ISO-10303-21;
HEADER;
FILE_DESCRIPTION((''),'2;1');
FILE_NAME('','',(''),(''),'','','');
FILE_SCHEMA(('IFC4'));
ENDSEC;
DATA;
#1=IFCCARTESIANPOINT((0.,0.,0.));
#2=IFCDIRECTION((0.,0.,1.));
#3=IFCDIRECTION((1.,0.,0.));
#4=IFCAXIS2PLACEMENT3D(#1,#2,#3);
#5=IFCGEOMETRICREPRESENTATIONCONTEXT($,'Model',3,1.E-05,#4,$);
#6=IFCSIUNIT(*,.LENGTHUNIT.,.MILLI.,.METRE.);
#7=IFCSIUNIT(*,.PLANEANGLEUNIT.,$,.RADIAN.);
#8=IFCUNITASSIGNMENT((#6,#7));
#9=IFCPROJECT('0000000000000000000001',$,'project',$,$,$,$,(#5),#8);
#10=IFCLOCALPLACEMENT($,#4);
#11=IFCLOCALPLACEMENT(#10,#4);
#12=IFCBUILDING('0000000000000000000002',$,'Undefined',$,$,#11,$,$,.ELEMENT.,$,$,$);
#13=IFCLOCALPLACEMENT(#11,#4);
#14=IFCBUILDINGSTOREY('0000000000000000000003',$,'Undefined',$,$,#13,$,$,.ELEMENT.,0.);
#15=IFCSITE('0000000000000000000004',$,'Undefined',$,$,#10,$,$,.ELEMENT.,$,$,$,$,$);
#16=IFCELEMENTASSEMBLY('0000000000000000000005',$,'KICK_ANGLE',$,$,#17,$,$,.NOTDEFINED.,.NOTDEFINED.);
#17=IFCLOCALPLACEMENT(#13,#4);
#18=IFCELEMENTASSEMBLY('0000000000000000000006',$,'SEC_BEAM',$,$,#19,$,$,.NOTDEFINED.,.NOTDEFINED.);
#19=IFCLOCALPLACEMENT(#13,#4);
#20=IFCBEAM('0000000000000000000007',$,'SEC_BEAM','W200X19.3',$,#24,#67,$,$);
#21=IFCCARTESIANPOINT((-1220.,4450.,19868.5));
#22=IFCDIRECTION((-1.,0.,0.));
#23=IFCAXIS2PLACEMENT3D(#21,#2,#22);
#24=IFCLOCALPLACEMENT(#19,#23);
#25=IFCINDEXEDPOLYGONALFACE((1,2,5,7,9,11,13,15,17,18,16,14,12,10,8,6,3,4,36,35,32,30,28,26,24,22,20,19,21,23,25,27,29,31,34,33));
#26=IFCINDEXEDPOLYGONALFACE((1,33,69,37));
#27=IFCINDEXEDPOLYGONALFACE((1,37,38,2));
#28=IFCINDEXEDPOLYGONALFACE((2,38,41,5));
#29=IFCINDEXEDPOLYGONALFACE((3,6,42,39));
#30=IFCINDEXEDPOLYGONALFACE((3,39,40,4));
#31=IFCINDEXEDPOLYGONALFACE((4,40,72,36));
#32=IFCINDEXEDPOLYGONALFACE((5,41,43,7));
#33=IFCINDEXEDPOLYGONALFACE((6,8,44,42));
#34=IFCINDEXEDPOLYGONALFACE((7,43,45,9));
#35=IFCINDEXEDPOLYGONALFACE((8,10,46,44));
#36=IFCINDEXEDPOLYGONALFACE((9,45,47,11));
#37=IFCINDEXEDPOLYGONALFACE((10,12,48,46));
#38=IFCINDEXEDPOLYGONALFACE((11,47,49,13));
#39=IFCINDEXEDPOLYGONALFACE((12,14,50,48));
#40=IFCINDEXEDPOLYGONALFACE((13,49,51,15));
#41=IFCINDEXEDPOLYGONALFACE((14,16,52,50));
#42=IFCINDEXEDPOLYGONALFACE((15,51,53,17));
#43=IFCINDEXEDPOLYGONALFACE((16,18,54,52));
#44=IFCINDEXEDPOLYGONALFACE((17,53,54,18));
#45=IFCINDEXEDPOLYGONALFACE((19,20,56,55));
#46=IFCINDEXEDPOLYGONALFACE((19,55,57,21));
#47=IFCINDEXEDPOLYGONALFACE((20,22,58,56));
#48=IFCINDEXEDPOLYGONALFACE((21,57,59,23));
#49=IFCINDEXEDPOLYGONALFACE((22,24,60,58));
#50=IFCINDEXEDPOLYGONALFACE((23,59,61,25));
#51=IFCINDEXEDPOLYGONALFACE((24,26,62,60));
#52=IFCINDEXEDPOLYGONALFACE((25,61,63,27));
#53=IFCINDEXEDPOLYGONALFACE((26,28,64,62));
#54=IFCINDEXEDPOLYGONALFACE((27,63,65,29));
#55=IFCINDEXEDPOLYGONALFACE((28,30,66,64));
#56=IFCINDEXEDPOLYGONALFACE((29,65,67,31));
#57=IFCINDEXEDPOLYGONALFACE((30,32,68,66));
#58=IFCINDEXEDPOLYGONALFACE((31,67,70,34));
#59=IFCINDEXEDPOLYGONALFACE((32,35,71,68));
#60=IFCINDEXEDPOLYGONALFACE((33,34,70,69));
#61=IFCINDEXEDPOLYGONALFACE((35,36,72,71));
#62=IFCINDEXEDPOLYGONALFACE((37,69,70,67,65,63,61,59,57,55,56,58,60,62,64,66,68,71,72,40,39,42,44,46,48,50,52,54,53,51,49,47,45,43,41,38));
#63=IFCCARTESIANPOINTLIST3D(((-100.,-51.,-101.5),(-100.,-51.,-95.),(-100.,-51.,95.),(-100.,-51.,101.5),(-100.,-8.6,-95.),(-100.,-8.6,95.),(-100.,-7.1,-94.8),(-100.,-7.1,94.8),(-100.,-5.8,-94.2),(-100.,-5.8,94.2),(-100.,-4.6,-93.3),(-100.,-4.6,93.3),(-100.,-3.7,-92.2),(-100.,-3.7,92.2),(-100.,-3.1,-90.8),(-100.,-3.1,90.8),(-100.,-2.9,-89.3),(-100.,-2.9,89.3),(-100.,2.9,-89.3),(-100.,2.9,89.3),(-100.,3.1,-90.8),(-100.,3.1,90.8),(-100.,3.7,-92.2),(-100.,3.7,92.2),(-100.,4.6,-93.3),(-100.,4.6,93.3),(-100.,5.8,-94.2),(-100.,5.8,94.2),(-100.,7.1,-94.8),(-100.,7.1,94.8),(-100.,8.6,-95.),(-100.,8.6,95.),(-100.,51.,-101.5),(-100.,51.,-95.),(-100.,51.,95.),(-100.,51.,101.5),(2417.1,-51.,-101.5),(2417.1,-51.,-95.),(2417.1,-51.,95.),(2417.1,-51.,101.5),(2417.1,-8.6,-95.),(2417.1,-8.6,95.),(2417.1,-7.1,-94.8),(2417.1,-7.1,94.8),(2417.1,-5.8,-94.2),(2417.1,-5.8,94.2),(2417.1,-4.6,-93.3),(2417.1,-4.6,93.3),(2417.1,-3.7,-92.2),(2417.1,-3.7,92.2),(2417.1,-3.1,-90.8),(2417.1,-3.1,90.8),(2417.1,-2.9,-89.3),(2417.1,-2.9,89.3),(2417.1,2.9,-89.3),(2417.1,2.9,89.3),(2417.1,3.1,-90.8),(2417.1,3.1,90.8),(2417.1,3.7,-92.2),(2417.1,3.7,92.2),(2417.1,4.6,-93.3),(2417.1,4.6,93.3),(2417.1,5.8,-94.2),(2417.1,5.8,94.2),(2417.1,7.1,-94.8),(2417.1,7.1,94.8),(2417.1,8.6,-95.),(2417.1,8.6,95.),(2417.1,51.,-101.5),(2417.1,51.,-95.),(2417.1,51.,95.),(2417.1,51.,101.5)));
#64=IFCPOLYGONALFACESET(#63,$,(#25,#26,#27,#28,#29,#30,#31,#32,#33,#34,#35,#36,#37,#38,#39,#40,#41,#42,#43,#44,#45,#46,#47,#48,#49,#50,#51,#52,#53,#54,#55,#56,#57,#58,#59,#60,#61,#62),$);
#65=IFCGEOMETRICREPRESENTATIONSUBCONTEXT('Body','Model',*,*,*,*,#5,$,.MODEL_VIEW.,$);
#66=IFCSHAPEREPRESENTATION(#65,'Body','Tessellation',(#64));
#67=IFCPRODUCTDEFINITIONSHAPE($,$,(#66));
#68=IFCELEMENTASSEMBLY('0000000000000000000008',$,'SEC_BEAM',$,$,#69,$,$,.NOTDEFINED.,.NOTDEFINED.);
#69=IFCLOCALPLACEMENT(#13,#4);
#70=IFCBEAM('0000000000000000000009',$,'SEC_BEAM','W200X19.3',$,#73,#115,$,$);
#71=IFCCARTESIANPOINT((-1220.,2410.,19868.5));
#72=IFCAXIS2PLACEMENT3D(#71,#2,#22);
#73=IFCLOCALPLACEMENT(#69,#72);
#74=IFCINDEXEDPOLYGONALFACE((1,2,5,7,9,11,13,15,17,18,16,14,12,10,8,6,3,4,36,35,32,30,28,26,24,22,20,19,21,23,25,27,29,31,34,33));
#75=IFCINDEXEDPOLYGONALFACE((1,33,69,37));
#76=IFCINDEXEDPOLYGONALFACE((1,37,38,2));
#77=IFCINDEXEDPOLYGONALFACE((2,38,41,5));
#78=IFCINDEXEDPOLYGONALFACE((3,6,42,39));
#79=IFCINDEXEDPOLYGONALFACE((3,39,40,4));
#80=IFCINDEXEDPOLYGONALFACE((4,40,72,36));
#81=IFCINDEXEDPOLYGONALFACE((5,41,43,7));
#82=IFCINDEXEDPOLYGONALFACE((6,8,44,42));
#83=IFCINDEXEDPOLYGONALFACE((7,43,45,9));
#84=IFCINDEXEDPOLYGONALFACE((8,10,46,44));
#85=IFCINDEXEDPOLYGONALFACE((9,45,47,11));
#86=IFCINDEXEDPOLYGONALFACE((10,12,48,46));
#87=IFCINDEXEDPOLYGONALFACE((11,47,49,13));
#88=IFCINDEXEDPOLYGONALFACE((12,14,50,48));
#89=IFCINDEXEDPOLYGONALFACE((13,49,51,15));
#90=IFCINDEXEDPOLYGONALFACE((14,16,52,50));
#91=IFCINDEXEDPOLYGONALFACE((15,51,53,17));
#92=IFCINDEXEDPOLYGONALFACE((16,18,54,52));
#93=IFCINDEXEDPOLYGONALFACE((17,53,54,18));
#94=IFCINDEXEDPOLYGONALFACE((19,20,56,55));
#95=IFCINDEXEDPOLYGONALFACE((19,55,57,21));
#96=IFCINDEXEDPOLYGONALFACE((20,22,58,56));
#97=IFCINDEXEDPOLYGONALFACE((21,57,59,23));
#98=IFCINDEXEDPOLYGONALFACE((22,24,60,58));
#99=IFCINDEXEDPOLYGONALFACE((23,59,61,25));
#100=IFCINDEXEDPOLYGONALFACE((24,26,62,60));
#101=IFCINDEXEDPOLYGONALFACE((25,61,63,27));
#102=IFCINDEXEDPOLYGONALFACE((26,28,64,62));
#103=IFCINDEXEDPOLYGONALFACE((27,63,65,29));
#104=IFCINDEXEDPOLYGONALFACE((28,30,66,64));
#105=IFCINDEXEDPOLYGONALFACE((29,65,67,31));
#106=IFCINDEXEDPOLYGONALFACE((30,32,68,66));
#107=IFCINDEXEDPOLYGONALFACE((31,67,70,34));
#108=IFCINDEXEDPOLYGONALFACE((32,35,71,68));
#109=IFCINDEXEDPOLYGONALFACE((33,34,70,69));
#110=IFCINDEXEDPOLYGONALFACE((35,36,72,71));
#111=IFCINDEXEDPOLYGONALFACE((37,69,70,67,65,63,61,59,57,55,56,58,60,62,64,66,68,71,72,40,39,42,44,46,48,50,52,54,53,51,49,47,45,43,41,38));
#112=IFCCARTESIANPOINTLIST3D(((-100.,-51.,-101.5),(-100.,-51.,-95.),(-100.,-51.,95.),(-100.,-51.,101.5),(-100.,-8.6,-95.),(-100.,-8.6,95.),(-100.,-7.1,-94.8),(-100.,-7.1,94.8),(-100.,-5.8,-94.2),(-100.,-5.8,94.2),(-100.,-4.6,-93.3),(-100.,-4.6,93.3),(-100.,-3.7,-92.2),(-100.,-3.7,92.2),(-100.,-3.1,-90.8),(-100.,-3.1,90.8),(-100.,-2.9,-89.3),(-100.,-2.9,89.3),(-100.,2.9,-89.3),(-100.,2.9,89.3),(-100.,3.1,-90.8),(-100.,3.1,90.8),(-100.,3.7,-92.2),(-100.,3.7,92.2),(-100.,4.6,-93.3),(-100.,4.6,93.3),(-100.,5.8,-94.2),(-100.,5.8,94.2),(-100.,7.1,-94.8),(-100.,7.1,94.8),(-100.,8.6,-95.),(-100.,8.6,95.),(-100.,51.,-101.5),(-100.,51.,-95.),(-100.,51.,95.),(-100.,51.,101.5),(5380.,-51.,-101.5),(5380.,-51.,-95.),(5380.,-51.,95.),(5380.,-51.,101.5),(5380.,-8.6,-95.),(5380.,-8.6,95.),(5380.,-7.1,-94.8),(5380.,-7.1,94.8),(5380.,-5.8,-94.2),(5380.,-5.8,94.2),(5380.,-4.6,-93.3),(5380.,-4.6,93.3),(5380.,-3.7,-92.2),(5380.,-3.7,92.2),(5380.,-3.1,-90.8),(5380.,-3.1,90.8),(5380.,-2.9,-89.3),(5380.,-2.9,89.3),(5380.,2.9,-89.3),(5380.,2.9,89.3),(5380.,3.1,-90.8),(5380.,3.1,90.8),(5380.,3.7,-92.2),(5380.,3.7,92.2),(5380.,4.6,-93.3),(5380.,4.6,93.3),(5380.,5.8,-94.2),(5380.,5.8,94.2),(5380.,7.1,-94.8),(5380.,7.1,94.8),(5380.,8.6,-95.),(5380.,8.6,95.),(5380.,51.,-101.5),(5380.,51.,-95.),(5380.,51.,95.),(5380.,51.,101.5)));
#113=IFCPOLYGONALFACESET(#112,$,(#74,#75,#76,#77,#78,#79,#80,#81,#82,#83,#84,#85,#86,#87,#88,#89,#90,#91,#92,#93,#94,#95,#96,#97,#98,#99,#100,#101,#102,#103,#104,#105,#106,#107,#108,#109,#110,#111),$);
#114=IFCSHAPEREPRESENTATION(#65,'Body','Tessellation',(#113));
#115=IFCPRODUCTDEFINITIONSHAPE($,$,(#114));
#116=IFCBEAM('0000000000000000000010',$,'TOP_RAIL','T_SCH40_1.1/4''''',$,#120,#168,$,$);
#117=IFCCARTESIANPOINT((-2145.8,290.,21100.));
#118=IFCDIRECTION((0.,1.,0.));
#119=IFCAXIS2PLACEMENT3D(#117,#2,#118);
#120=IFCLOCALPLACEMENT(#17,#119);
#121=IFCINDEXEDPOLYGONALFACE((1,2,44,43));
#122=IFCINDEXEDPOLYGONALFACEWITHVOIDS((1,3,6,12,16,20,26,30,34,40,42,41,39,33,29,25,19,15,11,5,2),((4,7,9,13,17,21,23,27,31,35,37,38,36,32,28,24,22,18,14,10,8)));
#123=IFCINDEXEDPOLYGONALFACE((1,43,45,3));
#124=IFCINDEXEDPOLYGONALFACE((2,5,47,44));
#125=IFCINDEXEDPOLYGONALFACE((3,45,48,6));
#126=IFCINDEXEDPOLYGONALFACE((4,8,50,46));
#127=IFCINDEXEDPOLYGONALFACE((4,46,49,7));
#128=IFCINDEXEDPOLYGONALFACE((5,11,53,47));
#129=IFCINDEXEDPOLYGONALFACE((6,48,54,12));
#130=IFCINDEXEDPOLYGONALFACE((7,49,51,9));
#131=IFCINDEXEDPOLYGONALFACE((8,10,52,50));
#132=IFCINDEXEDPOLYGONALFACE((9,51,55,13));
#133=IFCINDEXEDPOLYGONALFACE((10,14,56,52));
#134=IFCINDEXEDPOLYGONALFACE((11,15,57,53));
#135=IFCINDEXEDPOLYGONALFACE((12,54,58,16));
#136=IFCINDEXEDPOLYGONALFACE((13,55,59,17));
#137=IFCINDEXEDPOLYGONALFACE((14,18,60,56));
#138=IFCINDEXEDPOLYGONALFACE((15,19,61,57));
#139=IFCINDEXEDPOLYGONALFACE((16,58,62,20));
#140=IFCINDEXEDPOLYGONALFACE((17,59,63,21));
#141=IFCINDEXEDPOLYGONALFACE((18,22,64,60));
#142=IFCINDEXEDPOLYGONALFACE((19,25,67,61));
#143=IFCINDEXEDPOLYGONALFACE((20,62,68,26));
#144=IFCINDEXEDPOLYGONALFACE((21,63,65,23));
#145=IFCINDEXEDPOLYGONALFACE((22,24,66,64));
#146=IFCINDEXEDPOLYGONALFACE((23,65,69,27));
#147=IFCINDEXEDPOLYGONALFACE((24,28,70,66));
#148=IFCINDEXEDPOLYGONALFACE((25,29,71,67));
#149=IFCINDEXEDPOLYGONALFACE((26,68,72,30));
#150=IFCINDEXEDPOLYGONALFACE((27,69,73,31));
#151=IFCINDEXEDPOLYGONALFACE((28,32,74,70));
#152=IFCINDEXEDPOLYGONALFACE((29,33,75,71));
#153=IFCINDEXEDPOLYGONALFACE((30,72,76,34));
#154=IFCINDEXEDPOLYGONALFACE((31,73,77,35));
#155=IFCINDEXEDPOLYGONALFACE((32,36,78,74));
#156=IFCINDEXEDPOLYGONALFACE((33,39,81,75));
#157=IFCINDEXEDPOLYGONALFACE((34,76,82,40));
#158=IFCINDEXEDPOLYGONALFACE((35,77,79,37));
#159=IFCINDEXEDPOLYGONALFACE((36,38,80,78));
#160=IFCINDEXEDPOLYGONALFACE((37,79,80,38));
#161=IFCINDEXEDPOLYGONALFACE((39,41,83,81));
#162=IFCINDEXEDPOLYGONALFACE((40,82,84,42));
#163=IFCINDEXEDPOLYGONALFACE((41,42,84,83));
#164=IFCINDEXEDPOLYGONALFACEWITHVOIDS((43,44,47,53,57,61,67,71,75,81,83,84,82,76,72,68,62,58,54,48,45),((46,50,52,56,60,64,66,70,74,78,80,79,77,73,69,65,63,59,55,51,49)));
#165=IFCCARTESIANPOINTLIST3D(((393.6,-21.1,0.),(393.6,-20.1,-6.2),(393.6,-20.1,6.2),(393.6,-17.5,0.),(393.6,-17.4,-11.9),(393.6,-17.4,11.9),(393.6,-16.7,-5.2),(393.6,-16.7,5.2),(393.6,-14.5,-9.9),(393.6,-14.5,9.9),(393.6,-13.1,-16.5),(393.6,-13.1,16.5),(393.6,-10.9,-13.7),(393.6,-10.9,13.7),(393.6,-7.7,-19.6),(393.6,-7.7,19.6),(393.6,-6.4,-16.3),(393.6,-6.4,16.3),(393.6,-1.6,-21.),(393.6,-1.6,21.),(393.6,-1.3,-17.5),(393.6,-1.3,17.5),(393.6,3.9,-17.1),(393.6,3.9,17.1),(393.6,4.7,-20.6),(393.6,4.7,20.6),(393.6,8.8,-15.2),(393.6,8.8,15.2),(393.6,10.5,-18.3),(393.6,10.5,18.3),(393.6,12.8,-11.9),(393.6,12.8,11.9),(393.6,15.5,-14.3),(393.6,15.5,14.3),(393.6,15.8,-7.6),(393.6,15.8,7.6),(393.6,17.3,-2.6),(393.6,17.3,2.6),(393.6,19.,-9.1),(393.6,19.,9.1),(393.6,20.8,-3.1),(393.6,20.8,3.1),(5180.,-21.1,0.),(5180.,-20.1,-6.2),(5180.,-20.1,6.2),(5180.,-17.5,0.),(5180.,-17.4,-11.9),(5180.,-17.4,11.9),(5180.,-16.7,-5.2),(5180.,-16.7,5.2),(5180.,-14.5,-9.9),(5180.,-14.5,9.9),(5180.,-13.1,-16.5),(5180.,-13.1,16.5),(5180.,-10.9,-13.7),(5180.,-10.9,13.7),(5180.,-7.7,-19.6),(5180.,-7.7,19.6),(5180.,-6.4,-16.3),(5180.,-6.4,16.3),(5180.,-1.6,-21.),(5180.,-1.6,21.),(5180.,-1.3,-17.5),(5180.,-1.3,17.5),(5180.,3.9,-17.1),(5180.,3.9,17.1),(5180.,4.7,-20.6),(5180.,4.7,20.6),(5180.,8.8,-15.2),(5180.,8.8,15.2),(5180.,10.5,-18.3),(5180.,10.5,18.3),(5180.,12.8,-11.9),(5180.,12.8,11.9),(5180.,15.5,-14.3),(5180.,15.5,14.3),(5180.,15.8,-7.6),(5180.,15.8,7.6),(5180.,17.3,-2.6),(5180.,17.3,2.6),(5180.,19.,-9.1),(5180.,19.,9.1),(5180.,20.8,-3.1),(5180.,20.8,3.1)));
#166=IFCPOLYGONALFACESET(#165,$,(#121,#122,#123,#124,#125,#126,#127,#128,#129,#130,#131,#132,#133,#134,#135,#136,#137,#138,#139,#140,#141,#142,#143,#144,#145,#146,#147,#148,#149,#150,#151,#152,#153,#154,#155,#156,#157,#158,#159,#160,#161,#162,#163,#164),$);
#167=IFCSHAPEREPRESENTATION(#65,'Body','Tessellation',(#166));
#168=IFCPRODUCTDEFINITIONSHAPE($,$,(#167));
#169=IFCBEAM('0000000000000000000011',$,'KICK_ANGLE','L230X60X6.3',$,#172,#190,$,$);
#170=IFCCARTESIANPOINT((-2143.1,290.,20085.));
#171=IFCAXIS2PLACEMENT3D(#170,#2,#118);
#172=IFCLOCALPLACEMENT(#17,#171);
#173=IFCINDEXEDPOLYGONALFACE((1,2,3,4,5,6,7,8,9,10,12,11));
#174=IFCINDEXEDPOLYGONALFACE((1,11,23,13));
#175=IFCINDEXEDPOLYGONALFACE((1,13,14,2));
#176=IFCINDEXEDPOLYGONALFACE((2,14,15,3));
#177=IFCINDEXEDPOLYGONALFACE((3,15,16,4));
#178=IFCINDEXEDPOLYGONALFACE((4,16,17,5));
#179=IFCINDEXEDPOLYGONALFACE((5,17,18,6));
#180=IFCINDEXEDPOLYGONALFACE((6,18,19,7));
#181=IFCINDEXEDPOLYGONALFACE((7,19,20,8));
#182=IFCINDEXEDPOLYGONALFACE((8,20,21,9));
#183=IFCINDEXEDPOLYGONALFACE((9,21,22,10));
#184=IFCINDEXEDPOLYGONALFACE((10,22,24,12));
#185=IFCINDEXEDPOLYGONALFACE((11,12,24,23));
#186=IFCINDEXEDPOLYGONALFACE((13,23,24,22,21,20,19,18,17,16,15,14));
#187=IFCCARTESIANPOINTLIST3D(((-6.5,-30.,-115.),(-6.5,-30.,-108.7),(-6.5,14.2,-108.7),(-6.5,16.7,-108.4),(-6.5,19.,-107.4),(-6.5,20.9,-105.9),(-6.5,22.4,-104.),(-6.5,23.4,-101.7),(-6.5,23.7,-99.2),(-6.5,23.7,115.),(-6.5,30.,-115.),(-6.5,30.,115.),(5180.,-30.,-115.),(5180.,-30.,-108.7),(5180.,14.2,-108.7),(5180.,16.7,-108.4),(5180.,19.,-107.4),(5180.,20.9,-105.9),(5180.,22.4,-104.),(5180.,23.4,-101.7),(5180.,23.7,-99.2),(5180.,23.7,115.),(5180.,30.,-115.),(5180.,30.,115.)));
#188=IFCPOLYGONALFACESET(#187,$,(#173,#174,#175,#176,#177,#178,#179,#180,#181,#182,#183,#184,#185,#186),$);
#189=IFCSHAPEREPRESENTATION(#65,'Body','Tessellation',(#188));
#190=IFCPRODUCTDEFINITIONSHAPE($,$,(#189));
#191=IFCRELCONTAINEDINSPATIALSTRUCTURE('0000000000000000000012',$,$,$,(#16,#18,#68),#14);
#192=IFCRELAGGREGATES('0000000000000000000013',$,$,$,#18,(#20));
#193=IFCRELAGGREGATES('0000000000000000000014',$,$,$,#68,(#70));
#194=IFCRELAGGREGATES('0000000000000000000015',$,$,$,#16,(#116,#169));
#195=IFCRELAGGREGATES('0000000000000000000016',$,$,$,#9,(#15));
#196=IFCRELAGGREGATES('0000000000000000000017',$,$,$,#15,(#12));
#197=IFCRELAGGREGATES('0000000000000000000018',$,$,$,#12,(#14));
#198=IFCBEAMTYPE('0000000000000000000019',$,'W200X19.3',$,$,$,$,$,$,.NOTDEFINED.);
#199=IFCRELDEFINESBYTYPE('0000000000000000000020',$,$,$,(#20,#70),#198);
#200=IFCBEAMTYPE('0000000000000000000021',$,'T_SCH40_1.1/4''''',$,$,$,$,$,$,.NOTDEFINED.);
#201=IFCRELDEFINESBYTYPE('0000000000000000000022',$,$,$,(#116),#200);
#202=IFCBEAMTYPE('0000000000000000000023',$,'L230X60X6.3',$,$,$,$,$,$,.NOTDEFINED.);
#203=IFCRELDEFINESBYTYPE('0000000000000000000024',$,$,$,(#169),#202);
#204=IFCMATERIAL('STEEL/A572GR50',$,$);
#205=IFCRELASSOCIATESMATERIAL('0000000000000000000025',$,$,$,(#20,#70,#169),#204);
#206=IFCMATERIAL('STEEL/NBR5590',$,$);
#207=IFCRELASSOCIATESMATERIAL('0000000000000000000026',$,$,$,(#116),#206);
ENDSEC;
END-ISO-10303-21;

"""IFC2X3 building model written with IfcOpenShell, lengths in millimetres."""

from ifc_helpers import new_model, si_unit, frame, origin_with_axes, origin_2d_with_axis, place, context, subcontext, project, spatial, hollow_circle, i_section, l_section, extrude, clip, halfspace, material, type_object, element, aggregate, save


model = new_model("IFC2X3")

# Units and contexts
model_context = context("Model", 3, precision=1e-05, world=origin_with_axes())
body_context = subcontext(model_context, "Body", "Model", "MODEL_VIEW")
ifc_project = project(units=[si_unit("LENGTHUNIT", "METRE", prefix="MILLI"), si_unit("PLANEANGLEUNIT", "RADIAN")], contexts=[model_context])

# Site, building, storey
site_placement = place(None, origin_with_axes())
site = spatial("IfcSite", under=ifc_project, at=site_placement, Name="Undefined", CompositionType="ELEMENT")
building_placement = place(site_placement, origin_with_axes())
building = spatial("IfcBuilding", under=site, at=building_placement, Name="Undefined", CompositionType="ELEMENT")
storey_placement = place(building_placement, origin_with_axes())
storey = spatial("IfcBuildingStorey", under=building, at=storey_placement, Name="Undefined", CompositionType="ELEMENT", Elevation=0.0)

# Shared definitions
ifc_material_1 = material(Name="STEEL/A572GR50")

# Element assembly
assembly_1_placement = place(storey_placement, origin_with_axes())
assembly_1 = element("IfcElementAssembly", 1, at=assembly_1_placement, inside=storey, Name="KICK_ANGLE", AssemblyPlace="NOTDEFINED", PredefinedType="NOTDEFINED")
ifc_material_2 = material(Name="STEEL/NBR5590")

# Element assemblies, beams
assembly_2_placement = place(storey_placement, origin_with_axes())
assembly_2 = element("IfcElementAssembly", 2, at=assembly_2_placement, inside=storey, Name="SEC_BEAM", AssemblyPlace="NOTDEFINED", PredefinedType="NOTDEFINED")
beam_type_1 = type_object("IfcBeamType", Name="W200X19.3", PredefinedType="NOTDEFINED")
beam_1_placement = place(assembly_2_placement, frame((-1220.0, 4450.0, 19868.5), z_axis=(0.0, 0.0, 1.0), x_axis=(-1.0, 0.0, 0.0)))
beam_1 = element("IfcBeam", 3, at=beam_1_placement, type_object=beam_type_1, material=ifc_material_1, Name="SEC_BEAM", Description="W200X19.3", context=body_context, shape_type="Clipping", body=[
    clip(extrude(i_section(OverallWidth=102.0, OverallDepth=203.0, WebThickness=5.8, FlangeThickness=6.5, FilletRadius=5.7, at=origin_2d_with_axis()), frame((2417.1, 0.0, 0.0), z_axis=(-1.0, 0.0, 0.0), x_axis=(0.0, -1.0, 0.0)), (0.0, 0.0, 1.0), 2517.1), halfspace(frame((-100.0, 0.0, 0.0), z_axis=(1.0, 0.0, 0.0), x_axis=(0.0, -1.0, 0.0)), True)),
])
assembly_3_placement = place(storey_placement, origin_with_axes())
assembly_3 = element("IfcElementAssembly", 4, at=assembly_3_placement, inside=storey, Name="SEC_BEAM", AssemblyPlace="NOTDEFINED", PredefinedType="NOTDEFINED")
beam_2_placement = place(assembly_3_placement, frame((-1220.0, 2410.0, 19868.5), z_axis=(0.0, 0.0, 1.0), x_axis=(-1.0, 0.0, 0.0)))
beam_2 = element("IfcBeam", 5, at=beam_2_placement, type_object=beam_type_1, material=ifc_material_1, Name="SEC_BEAM", Description="W200X19.3", context=body_context, shape_type="Clipping", body=[
    clip(clip(extrude(i_section(OverallWidth=102.0, OverallDepth=203.0, WebThickness=5.8, FlangeThickness=6.5, FilletRadius=5.7, at=origin_2d_with_axis()), frame((5380.0, 0.0, 0.0), z_axis=(-1.0, 0.0, 0.0), x_axis=(0.0, -1.0, 0.0)), (0.0, 0.0, 1.0), 5480.0), halfspace(frame((5380.0, 0.0, 0.0), z_axis=(-1.0, 0.0, 0.0), x_axis=(0.0, 1.0, 0.0)), True)), halfspace(frame((-100.0, 0.0, 0.0), z_axis=(1.0, 0.0, 0.0), x_axis=(0.0, -1.0, 0.0)), True)),
])

# Beams
beam_type_2 = type_object("IfcBeamType", Name="T_SCH40_1.1/4''", PredefinedType="NOTDEFINED")
beam_3_placement = place(assembly_1_placement, frame((-2145.8, 290.0, 21100.0), z_axis=(0.0, 0.0, 1.0), x_axis=(0.0, 1.0, 0.0)))
beam_3 = element("IfcBeam", 6, at=beam_3_placement, type_object=beam_type_2, material=ifc_material_2, Name="TOP_RAIL", Description="T_SCH40_1.1/4''", context=body_context, shape_type="Clipping", body=[
    clip(extrude(hollow_circle(Radius=21.1, WallThickness=3.6, at=origin_2d_with_axis()), frame((5180.0, 0.0, 0.0), z_axis=(-1.0, 0.0, 0.0), x_axis=(0.0, -1.0, 0.0)), (0.0, 0.0, 1.0), 5180.0), halfspace(frame((393.6, 0.0, 0.0), z_axis=(1.0, 0.0, 0.0), x_axis=(0.0, -1.0, 0.0)), True)),
])
beam_type_3 = type_object("IfcBeamType", Name="L230X60X6.3", PredefinedType="NOTDEFINED")
beam_4_placement = place(assembly_1_placement, frame((-2143.1, 290.0, 20085.0), z_axis=(0.0, 0.0, 1.0), x_axis=(0.0, 1.0, 0.0)))
beam_4 = element("IfcBeam", 7, at=beam_4_placement, type_object=beam_type_3, material=ifc_material_1, Name="KICK_ANGLE", Description="L230X60X6.3", context=body_context, shape_type="Clipping", body=[
    clip(clip(extrude(l_section(Depth=230.0, Width=60.0, Thickness=6.3, FilletRadius=9.4, at=origin_2d_with_axis()), frame((5180.0, 0.0, 0.0), z_axis=(-1.0, 0.0, 0.0), x_axis=(0.0, -1.0, 0.0)), (0.0, 0.0, 1.0), 5186.5), halfspace(frame((5180.0, 0.0, 0.0), z_axis=(-1.0, 0.0, 0.0), x_axis=(0.0, 1.0, 0.0)), True)), halfspace(frame((-6.5, 0.0, 0.0), z_axis=(1.0, 0.0, 0.0), x_axis=(0.0, -1.0, 0.0)), True)),
])

aggregate(assembly_2, [beam_1])
aggregate(assembly_3, [beam_2])
aggregate(assembly_1, [beam_3, beam_4])

save(model, "model.ifc")
